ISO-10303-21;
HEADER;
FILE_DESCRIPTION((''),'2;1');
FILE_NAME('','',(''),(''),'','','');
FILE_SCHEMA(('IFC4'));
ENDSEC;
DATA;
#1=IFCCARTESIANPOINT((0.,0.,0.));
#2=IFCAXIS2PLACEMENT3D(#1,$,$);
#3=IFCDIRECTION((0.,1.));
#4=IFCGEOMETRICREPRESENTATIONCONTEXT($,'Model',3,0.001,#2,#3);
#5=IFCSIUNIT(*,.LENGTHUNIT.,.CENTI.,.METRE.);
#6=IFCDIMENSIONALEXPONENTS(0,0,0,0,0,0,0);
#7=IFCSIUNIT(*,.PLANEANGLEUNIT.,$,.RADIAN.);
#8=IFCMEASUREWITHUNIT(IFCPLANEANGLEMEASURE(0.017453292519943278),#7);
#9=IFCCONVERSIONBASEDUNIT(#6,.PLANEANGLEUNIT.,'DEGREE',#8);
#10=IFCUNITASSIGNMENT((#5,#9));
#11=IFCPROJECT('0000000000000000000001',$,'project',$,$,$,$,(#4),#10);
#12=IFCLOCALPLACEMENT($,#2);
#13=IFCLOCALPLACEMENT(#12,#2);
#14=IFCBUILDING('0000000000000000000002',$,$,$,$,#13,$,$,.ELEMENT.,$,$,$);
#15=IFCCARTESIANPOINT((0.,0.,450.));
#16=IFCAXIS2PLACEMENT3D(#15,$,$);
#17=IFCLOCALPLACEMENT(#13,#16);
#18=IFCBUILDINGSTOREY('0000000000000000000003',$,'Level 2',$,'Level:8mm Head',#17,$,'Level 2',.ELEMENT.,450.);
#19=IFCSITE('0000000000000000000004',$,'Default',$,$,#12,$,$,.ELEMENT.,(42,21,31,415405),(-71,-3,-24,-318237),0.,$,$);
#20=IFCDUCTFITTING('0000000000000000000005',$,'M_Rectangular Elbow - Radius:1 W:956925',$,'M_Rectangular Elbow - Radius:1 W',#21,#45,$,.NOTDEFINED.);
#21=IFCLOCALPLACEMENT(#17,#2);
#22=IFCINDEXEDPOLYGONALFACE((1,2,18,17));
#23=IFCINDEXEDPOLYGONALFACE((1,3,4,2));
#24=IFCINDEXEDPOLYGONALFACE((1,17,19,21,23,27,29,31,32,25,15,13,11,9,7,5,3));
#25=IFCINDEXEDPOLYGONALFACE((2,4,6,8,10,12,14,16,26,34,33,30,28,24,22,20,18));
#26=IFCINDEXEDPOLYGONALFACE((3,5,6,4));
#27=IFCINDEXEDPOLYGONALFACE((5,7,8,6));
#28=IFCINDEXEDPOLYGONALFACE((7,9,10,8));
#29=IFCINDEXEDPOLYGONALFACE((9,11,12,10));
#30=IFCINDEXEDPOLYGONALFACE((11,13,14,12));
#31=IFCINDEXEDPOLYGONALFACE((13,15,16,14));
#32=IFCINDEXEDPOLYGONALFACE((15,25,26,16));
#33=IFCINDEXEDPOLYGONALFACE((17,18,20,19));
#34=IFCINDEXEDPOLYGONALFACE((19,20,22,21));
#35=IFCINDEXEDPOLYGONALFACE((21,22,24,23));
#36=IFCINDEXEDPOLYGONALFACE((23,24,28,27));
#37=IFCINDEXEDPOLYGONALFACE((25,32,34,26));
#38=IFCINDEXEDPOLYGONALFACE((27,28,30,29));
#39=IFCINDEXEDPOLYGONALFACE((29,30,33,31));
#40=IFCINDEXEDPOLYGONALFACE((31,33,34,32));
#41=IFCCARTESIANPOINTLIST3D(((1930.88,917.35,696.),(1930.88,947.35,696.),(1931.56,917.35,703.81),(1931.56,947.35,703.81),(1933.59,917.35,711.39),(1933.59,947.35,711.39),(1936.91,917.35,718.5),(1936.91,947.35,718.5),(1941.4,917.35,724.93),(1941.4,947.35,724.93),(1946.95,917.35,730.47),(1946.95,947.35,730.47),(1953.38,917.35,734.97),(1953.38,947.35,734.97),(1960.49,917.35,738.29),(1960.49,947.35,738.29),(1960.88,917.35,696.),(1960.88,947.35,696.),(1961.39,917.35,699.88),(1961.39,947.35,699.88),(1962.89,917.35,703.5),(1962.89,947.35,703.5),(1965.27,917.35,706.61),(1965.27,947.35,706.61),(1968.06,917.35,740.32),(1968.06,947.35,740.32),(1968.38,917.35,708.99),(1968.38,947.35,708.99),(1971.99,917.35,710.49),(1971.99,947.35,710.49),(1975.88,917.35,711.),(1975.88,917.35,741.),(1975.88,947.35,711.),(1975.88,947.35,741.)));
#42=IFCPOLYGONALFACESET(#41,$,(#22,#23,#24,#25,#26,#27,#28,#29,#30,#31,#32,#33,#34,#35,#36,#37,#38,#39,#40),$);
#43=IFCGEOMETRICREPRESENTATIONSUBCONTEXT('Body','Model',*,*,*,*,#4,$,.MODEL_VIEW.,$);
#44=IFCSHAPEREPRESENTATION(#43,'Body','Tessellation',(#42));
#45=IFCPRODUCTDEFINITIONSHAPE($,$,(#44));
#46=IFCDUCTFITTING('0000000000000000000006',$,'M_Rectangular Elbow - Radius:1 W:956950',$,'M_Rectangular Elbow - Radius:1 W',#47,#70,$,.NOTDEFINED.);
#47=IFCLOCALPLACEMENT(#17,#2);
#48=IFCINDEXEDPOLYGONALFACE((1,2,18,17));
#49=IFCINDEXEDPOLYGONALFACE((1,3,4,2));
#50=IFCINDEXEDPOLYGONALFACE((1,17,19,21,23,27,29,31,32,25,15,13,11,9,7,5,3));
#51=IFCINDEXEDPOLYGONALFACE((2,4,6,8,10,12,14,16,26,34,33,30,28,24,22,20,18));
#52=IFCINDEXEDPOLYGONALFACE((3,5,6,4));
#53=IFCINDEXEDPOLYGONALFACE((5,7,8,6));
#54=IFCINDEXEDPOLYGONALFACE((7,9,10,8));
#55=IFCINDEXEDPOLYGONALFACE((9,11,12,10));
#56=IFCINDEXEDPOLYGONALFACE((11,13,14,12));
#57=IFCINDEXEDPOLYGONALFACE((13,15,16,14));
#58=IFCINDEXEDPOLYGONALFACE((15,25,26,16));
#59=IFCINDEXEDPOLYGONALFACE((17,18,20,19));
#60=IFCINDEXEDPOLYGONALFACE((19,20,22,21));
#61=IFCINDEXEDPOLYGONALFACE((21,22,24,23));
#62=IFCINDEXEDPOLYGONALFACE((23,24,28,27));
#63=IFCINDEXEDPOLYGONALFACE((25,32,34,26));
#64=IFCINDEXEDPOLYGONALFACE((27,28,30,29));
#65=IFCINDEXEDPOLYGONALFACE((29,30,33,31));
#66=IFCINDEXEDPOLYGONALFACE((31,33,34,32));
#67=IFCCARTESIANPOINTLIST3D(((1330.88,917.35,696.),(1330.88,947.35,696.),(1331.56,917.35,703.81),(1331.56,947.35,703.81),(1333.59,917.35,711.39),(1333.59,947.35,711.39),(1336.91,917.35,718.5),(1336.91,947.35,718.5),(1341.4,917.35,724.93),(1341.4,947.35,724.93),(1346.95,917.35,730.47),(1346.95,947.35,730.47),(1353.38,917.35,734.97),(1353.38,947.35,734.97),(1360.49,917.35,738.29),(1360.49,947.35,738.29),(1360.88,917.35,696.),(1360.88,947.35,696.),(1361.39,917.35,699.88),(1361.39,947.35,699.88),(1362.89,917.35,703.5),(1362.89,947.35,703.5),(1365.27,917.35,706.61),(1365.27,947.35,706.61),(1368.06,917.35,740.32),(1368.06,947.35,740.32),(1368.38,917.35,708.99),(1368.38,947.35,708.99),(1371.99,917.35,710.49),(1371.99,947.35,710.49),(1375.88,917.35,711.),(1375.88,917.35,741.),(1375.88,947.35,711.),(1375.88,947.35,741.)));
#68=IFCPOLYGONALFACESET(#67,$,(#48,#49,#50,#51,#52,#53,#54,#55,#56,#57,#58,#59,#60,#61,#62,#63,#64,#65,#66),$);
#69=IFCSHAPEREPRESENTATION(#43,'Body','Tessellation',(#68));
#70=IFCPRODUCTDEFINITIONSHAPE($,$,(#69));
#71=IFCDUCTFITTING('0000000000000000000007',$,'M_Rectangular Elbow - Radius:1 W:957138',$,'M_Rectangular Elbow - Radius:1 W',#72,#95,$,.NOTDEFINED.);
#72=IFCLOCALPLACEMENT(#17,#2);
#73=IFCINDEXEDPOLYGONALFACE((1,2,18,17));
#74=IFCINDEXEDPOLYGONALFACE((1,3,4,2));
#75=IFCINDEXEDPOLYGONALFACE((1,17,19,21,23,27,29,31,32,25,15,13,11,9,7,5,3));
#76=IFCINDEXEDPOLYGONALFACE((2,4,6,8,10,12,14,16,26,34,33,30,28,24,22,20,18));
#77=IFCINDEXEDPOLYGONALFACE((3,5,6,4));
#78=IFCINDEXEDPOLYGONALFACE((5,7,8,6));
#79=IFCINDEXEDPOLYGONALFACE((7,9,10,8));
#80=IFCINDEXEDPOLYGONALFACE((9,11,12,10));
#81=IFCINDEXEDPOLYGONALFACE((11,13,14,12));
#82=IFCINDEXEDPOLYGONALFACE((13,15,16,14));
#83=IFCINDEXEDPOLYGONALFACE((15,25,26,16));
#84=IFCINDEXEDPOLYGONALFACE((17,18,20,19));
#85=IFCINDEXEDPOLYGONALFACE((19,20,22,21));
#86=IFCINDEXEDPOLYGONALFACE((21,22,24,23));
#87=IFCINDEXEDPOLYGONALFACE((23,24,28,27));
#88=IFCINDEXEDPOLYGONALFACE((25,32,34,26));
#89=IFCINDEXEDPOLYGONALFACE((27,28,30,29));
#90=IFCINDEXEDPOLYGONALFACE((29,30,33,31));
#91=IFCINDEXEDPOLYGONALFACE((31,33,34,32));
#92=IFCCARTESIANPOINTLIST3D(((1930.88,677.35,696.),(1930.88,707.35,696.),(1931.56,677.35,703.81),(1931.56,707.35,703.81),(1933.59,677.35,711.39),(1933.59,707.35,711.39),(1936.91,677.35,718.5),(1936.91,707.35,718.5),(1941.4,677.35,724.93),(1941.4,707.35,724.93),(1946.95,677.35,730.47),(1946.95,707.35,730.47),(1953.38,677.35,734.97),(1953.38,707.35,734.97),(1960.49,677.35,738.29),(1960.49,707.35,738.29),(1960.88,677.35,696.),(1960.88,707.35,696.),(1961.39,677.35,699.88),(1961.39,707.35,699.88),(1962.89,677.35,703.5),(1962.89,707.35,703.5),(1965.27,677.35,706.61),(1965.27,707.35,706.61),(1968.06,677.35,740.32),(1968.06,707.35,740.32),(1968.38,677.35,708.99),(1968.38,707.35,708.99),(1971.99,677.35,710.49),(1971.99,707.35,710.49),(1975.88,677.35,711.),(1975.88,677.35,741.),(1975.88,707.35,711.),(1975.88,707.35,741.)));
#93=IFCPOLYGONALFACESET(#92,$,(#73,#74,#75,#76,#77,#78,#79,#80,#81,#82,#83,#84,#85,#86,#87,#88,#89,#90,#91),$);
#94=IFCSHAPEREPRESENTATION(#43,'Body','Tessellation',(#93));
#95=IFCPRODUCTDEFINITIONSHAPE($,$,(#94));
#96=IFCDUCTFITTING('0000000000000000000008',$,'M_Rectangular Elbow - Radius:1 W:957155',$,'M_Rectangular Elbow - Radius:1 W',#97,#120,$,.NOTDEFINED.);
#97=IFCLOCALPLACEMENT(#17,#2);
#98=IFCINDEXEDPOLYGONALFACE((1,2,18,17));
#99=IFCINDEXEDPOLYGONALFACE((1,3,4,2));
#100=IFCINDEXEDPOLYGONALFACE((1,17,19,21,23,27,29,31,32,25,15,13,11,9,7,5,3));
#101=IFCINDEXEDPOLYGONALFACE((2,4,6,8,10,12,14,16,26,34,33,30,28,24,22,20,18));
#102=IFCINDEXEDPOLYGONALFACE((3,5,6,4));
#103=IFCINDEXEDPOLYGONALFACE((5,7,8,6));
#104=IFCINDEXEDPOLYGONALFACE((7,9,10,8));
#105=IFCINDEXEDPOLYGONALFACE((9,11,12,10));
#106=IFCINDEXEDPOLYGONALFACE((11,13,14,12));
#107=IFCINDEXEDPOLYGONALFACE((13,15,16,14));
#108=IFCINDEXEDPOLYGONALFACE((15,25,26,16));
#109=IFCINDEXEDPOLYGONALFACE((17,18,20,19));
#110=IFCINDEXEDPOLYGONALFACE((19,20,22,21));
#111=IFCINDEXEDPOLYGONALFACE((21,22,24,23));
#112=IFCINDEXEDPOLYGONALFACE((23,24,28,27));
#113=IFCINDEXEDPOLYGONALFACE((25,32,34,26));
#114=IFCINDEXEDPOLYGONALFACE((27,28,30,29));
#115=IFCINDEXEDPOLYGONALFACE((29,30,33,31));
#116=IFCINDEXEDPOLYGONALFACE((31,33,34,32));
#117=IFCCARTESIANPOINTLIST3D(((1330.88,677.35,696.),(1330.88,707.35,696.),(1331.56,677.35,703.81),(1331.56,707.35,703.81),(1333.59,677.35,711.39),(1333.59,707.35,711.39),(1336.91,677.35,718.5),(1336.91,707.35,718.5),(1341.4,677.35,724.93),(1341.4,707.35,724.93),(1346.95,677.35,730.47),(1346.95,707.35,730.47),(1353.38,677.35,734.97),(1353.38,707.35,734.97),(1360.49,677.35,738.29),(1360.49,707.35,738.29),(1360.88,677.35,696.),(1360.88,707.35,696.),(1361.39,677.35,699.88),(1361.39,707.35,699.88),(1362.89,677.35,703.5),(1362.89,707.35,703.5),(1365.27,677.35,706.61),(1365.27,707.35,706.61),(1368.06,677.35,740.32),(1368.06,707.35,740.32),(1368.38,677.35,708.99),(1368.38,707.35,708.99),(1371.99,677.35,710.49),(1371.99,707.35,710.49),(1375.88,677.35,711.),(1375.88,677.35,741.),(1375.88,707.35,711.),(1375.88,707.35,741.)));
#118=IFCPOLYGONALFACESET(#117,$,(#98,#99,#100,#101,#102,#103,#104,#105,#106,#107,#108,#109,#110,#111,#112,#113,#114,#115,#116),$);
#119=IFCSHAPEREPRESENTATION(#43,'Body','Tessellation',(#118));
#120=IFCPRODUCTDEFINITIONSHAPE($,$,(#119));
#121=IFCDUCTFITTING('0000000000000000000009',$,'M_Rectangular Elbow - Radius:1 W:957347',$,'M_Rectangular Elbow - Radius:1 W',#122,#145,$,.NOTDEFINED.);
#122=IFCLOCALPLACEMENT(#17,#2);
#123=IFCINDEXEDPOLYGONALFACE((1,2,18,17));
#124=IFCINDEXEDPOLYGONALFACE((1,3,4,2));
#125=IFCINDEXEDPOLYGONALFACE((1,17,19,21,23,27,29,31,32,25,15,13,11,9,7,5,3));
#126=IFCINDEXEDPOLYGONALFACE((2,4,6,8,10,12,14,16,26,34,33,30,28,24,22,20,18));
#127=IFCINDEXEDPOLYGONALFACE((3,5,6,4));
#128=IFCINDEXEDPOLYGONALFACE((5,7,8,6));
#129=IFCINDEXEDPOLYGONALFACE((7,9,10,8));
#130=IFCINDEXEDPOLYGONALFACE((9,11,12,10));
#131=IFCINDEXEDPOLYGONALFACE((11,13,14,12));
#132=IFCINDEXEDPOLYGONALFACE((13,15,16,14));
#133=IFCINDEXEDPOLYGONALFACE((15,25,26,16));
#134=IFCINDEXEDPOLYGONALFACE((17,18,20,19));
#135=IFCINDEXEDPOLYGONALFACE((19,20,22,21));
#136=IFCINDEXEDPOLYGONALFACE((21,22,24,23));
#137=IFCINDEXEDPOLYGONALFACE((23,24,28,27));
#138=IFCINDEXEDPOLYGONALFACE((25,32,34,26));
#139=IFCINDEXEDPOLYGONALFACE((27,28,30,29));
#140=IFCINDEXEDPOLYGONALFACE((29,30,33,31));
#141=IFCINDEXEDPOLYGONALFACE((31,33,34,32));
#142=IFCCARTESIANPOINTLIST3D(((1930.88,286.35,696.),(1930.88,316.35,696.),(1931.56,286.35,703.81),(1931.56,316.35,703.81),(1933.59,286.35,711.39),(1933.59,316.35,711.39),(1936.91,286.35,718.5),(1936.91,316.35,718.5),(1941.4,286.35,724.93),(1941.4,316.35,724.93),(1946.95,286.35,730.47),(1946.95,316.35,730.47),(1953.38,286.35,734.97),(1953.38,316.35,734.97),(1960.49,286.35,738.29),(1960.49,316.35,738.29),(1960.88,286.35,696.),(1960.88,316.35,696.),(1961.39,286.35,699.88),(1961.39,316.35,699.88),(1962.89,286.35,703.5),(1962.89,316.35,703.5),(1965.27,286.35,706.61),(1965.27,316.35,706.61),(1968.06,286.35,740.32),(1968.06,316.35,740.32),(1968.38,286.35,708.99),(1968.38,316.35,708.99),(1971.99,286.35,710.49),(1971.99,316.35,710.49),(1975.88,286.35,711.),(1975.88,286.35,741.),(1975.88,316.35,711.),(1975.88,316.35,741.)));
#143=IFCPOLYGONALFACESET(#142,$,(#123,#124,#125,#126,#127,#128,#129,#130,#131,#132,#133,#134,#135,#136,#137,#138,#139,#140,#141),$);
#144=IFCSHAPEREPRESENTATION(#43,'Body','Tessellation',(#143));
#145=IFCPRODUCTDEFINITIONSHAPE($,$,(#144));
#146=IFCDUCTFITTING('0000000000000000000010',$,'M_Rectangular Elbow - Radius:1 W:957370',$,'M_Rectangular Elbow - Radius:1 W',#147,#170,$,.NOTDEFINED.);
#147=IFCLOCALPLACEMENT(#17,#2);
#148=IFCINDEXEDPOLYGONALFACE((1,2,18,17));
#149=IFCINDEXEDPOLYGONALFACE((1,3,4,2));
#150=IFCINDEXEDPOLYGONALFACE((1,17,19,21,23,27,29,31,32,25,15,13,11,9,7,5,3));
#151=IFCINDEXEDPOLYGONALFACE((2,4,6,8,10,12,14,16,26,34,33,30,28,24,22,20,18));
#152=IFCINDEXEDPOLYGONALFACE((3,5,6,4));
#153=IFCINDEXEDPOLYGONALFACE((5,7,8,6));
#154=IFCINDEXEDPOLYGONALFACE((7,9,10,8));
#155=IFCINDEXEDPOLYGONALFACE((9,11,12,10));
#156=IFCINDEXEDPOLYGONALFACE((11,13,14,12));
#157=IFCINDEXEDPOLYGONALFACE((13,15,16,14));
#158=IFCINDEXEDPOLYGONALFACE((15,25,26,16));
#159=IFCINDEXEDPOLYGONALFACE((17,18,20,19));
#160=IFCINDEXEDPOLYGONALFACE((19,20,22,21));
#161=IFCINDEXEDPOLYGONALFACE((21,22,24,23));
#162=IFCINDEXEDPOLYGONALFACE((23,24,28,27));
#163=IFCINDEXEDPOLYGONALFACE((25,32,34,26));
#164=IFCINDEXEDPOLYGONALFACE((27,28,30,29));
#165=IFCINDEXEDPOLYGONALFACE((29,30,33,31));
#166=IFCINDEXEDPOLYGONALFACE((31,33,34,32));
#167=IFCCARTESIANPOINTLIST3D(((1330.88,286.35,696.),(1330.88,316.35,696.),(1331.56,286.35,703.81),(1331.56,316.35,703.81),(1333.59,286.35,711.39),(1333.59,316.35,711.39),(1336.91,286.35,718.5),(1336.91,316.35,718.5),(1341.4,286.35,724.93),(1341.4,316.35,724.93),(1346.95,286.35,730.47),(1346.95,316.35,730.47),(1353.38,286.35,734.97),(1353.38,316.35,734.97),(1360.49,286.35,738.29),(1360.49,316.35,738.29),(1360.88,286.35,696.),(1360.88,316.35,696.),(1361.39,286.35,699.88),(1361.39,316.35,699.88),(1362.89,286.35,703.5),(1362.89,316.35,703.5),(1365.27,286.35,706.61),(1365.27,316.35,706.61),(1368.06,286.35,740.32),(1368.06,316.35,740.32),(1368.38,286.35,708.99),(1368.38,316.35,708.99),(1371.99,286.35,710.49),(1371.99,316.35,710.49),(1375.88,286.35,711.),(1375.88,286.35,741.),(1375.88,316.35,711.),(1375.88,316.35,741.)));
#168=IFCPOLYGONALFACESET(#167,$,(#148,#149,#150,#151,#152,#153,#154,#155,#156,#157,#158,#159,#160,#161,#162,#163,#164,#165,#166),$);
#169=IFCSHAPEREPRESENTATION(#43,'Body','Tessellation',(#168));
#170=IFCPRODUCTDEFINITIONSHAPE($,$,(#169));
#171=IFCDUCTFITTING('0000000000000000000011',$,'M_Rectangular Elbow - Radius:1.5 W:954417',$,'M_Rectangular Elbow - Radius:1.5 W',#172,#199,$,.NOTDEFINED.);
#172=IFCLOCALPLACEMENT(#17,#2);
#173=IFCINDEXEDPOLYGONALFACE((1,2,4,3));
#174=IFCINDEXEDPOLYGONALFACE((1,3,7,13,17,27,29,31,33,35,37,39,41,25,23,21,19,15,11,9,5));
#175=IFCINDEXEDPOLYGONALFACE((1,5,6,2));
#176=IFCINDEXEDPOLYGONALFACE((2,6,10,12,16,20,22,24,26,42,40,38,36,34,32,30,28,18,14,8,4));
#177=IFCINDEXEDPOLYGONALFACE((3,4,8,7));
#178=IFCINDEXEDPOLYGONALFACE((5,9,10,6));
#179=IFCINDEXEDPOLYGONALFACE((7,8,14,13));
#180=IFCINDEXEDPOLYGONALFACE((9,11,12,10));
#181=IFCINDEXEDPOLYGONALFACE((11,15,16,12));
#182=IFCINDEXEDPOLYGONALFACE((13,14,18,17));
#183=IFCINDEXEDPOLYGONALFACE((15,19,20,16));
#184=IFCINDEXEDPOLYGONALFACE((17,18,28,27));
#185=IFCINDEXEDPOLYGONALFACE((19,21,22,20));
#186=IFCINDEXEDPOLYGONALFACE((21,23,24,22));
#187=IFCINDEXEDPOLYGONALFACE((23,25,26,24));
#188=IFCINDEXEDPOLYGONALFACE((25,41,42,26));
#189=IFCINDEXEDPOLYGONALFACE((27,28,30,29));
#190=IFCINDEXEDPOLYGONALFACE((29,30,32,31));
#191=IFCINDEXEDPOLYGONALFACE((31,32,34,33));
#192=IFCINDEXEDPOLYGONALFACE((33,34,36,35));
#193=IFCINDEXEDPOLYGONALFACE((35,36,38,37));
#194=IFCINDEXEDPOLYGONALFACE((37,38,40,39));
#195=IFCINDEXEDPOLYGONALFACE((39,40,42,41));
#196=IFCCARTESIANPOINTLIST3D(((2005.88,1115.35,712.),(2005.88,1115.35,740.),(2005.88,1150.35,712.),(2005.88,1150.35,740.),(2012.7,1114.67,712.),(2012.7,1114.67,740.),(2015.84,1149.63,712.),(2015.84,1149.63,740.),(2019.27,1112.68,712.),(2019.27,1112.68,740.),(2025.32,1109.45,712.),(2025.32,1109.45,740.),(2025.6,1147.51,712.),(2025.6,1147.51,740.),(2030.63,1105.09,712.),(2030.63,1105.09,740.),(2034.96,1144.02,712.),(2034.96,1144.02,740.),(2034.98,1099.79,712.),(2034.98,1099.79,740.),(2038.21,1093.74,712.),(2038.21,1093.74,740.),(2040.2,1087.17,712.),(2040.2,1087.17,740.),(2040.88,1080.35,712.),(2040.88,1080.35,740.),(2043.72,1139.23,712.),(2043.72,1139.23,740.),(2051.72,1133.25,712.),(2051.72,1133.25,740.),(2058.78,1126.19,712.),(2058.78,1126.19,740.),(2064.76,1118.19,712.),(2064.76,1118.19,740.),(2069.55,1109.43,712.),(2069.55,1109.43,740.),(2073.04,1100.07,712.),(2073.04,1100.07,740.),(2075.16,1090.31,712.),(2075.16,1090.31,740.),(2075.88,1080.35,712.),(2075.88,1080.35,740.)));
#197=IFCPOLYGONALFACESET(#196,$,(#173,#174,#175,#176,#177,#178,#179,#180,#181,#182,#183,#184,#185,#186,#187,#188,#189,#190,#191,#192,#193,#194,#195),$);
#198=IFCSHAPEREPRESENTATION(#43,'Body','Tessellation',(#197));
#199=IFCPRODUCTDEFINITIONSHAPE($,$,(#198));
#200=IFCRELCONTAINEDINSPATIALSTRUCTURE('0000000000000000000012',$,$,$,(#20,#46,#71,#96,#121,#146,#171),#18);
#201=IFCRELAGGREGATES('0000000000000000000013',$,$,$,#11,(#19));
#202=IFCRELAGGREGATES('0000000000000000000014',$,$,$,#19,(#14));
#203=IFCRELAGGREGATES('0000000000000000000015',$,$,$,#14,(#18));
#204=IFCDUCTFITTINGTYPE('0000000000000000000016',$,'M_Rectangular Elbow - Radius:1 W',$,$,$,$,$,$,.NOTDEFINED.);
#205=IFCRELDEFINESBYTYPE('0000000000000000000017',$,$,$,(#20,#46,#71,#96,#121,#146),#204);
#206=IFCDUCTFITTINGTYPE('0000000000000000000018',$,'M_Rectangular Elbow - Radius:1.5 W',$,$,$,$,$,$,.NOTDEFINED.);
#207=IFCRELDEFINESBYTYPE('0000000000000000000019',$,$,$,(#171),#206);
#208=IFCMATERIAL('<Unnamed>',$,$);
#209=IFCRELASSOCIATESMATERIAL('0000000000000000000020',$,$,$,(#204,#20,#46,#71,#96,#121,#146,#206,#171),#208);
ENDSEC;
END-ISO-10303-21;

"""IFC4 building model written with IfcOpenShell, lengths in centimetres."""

from ifc_helpers import new_model, entity, si_unit, converted_unit, direction, frame, origin, place, context, subcontext, project, spatial, line, arc, indexed_curve, outline, extrude, source, transform, mapped, material, type_object, type_shapes, element, save


model = new_model("IFC4")

# Units and contexts
model_context = context("Model", 3, precision=0.001, world=origin(), true_north=direction((0.0, 1.0)))
body_context = subcontext(model_context, "Body", "Model", "MODEL_VIEW")
ifc_project = project(units=[si_unit("LENGTHUNIT", "METRE", prefix="CENTI"), converted_unit("PLANEANGLEUNIT", "DEGREE", entity("IfcPlaneAngleMeasure", 0.017453292519943278), si_unit("PLANEANGLEUNIT", "RADIAN"), dimensions=[0, 0, 0, 0, 0, 0, 0])], contexts=[model_context])

# Site, building, storey
site_placement = place(None, origin())
site = spatial("IfcSite", under=ifc_project, at=site_placement, Name="Default", CompositionType="ELEMENT", RefLatitude=(42, 21, 31, 415405), RefLongitude=(-71, -3, -24, -318237), RefElevation=0.0)
building_placement = place(site_placement, origin())
building = spatial("IfcBuilding", under=site, at=building_placement, CompositionType="ELEMENT")
storey_placement = place(building_placement, frame((0.0, 0.0, 450.0)))
storey = spatial("IfcBuildingStorey", under=building, at=storey_placement, Name="Level 2", ObjectType="Level:8mm Head", LongName="Level 2", CompositionType="ELEMENT", Elevation=450.0)

# Duct fittings
ifc_material = material(Name="<Unnamed>")
duct_fitting_type_1 = type_object("IfcDuctFittingType", Name="M_Rectangular Elbow - Radius:1 W", PredefinedType="NOTDEFINED", material=ifc_material)
shared_shape_1 = source(origin(), body_context, "Body", "SweptSolid", [
    extrude(outline(indexed_curve([(-30.0, -15.0), (0.0, -15.0), (4.39, -4.39), (15.0, 0.0), (15.0, 30.0), (-16.82, 16.82)], segments=[line(1, 2), arc(2, 3, 4), line(4, 5), arc(5, 6, 1)], self_intersect=False)), frame((-15.0, 15.0, -15.0), z_axis=(0.0, 0.0, 1.0), x_axis=(-1.0, 0.0, 0.0)), (0.0, 0.0, 1.0), 30.0),
])
type_shapes(duct_fitting_type_1, [shared_shape_1])
for number, where, z_axis, x_axis, name in (
    (1, (1945.88, 932.35, 726.0), (0.0, -1.0, 0.0), (-1.0, 0.0, 0.0), "M_Rectangular Elbow - Radius:1 W:956925"),
    (2, (1345.88, 932.35, 726.0), (0.0, -1.0, 0.0), (-1.0, 0.0, 0.0), "M_Rectangular Elbow - Radius:1 W:956950"),
    (3, (1945.88, 692.35, 726.0), (0.0, -1.0, 0.0), (-1.0, 0.0, 0.0), "M_Rectangular Elbow - Radius:1 W:957138"),
    (4, (1345.88, 692.35, 726.0), (0.0, -1.0, 0.0), (-1.0, 0.0, 0.0), "M_Rectangular Elbow - Radius:1 W:957155"),
    (5, (1945.88, 301.35, 726.0), (0.0, -1.0, 0.0), (-1.0, 0.0, 0.0), "M_Rectangular Elbow - Radius:1 W:957347"),
    (6, (1345.88, 301.35, 726.0), (0.0, -1.0, 0.0), (-1.0, 0.0, 0.0), "M_Rectangular Elbow - Radius:1 W:957370"),
):
    element("IfcDuctFitting", number, at=place(storey_placement, frame(where, z_axis=z_axis, x_axis=x_axis)), inside=storey, type_object=duct_fitting_type_1, material=ifc_material, Name=name, ObjectType="M_Rectangular Elbow - Radius:1 W", PredefinedType="NOTDEFINED", context=body_context, shape_type="MappedRepresentation", body=[
        mapped(shared_shape_1, transform((0.0, 0.0, 0.0), scale=1.0)),
    ])
duct_fitting_type_2 = type_object("IfcDuctFittingType", Name="M_Rectangular Elbow - Radius:1.5 W", PredefinedType="NOTDEFINED", material=ifc_material)
shared_shape_2 = source(origin(), body_context, "Body", "SweptSolid", [
    extrude(outline(indexed_curve([(-26.25, -43.75), (23.25, -23.25), (43.75, 26.25), (8.75, 26.25), (-1.5, 1.5), (-26.25, -8.75)], segments=[arc(1, 2, 3), line(3, 4), arc(4, 5, 6), line(6, 1)], self_intersect=False)), frame((-26.25, -26.25, -14.0), z_axis=(0.0, 0.0, 1.0), x_axis=(0.0, 1.0, 0.0)), (0.0, 0.0, 1.0), 28.0),
])
type_shapes(duct_fitting_type_2, [shared_shape_2])
duct_fitting_placement = place(storey_placement, frame((2058.38, 1132.85, 726.0)))
element("IfcDuctFitting", 7, at=duct_fitting_placement, inside=storey, type_object=duct_fitting_type_2, material=ifc_material, Name="M_Rectangular Elbow - Radius:1.5 W:954417", ObjectType="M_Rectangular Elbow - Radius:1.5 W", PredefinedType="NOTDEFINED", context=body_context, shape_type="MappedRepresentation", body=[
    mapped(shared_shape_2, transform((0.0, 0.0, 0.0), scale=1.0)),
])

save(model, "model.ifc")
